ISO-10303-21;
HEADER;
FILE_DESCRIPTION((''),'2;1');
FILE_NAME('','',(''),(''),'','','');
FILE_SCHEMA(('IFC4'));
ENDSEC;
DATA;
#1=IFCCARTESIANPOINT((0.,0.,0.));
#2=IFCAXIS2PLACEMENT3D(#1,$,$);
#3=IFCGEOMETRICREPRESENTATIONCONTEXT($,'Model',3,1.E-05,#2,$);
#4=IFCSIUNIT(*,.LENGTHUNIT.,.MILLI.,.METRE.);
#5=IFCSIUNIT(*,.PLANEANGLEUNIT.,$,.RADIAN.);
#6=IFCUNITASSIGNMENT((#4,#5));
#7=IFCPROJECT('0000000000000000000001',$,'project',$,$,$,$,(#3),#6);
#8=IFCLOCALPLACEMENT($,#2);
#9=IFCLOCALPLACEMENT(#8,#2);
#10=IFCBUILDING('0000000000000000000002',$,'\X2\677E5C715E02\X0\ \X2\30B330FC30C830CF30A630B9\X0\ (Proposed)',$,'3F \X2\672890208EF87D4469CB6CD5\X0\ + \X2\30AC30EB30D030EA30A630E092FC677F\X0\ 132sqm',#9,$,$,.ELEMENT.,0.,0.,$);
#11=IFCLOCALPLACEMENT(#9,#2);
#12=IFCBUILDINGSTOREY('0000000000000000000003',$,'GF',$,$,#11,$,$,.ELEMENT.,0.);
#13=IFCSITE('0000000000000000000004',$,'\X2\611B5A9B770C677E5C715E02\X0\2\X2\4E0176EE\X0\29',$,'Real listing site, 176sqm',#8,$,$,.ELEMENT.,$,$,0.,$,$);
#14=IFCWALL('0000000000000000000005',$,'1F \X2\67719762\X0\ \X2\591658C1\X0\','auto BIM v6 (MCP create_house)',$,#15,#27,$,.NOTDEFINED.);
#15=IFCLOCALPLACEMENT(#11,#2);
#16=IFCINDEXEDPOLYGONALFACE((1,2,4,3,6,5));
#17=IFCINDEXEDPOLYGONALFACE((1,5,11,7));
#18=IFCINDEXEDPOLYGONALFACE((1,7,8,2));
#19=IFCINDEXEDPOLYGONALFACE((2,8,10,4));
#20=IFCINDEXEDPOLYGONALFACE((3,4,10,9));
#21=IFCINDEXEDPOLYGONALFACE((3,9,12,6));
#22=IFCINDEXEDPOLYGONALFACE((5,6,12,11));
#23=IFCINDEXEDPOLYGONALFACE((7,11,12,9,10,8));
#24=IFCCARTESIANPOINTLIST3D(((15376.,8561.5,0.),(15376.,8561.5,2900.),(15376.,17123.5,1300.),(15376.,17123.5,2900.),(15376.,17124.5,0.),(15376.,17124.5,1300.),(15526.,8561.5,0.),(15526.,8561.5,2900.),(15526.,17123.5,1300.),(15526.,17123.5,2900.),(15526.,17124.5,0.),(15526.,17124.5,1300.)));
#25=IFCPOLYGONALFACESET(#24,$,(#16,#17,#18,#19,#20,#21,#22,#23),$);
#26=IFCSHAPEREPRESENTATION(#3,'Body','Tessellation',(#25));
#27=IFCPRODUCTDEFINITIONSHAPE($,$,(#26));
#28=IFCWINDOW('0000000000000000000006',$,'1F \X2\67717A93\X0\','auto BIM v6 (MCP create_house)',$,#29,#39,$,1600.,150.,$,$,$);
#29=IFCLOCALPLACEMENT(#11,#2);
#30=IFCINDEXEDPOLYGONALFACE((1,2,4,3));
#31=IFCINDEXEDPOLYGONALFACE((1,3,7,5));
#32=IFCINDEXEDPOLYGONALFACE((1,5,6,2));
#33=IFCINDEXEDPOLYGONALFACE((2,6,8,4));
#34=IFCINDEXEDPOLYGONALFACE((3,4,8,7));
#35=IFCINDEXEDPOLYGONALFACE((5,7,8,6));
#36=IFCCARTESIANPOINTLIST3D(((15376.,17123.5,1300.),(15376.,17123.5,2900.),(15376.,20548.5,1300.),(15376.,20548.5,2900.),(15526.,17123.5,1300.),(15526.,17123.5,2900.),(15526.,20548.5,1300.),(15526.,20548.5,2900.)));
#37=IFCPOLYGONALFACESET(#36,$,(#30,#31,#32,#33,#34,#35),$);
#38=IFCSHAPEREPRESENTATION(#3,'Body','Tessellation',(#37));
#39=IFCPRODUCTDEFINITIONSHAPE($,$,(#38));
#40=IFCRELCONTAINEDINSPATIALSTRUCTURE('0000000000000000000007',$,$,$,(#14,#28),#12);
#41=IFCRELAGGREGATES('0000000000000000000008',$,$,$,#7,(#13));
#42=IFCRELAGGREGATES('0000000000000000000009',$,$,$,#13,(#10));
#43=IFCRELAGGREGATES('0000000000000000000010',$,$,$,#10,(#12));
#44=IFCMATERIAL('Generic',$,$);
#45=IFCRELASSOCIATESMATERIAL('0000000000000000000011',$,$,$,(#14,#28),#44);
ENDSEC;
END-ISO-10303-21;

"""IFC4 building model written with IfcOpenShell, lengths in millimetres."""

from ifc_helpers import new_model, si_unit, frame, frame_2d, origin, place, context, project, spatial, rectangle, extrude, material, element, fill, save


model = new_model("IFC4")

# Units and contexts
model_context = context("Model", 3, precision=1e-05, world=origin())
ifc_project = project(units=[si_unit("LENGTHUNIT", "METRE", prefix="MILLI"), si_unit("PLANEANGLEUNIT", "RADIAN")], contexts=[model_context])

# Site, building, storey
site_placement = place(None, origin())
site = spatial("IfcSite", under=ifc_project, at=site_placement, Name="愛媛県松山市2丁目29", ObjectType="Real listing site, 176sqm", CompositionType="ELEMENT", RefElevation=0.0)
building_placement = place(site_placement, origin())
building = spatial("IfcBuilding", under=site, at=building_placement, Name="松山市 コートハウス (Proposed)", ObjectType="3F 木造軸組構法 + ガルバリウム鋼板 132sqm", CompositionType="ELEMENT", ElevationOfRefHeight=0.0, ElevationOfTerrain=0.0)
storey_placement = place(building_placement, origin())
storey = spatial("IfcBuildingStorey", under=building, at=storey_placement, Name="GF", CompositionType="ELEMENT", Elevation=0.0)

# Shared definitions
ifc_material = material(Name="Generic")

# Wall, opening, window
wall_1_placement = place(storey_placement, frame((7688.0, 4281.0, 0.0)))
wall_1 = element("IfcWall", 1, at=wall_1_placement, inside=storey, material=ifc_material, Name="1F 東面 外壁", Description="auto BIM v6 (MCP create_house)", PredefinedType="NOTDEFINED", context=model_context, shape_type="SweptSolid", body=[
    extrude(rectangle(XDim=150.0, YDim=8563.0, at=frame_2d((75.0, 4281.0))), frame((7688.0, 4281.0, 0.0)), (0.0, 0.0, 1.0), 2900.0),
])
opening_1_placement = place(storey_placement, frame((7688.0, 8562.0, 650.0)))
opening_1 = element("IfcOpeningElement", 2, at=opening_1_placement, cuts=wall_1, PredefinedType="NOTDEFINED", context=model_context, shape_type="SweptSolid", body=[
    extrude(rectangle(XDim=150.0, YDim=3425.0, at=frame_2d((75.0, 1712.0))), frame((7688.0, 8562.0, 650.0)), (0.0, 0.0, 1.0), 1600.0),
])
window_1_placement = place(storey_placement, frame((7688.0, 8562.0, 650.0)))
window_1 = element("IfcWindow", 3, at=window_1_placement, inside=storey, material=ifc_material, Name="1F 東窓", Description="auto BIM v6 (MCP create_house)", OverallHeight=1600.0, OverallWidth=150.0, context=model_context, shape_type="SweptSolid", body=[
    extrude(rectangle(XDim=150.0, YDim=3425.0, at=frame_2d((75.0, 1712.0))), frame((7688.0, 8562.0, 650.0)), (0.0, 0.0, 1.0), 1600.0),
])
fill(opening_1, window_1)

save(model, "model.ifc")
